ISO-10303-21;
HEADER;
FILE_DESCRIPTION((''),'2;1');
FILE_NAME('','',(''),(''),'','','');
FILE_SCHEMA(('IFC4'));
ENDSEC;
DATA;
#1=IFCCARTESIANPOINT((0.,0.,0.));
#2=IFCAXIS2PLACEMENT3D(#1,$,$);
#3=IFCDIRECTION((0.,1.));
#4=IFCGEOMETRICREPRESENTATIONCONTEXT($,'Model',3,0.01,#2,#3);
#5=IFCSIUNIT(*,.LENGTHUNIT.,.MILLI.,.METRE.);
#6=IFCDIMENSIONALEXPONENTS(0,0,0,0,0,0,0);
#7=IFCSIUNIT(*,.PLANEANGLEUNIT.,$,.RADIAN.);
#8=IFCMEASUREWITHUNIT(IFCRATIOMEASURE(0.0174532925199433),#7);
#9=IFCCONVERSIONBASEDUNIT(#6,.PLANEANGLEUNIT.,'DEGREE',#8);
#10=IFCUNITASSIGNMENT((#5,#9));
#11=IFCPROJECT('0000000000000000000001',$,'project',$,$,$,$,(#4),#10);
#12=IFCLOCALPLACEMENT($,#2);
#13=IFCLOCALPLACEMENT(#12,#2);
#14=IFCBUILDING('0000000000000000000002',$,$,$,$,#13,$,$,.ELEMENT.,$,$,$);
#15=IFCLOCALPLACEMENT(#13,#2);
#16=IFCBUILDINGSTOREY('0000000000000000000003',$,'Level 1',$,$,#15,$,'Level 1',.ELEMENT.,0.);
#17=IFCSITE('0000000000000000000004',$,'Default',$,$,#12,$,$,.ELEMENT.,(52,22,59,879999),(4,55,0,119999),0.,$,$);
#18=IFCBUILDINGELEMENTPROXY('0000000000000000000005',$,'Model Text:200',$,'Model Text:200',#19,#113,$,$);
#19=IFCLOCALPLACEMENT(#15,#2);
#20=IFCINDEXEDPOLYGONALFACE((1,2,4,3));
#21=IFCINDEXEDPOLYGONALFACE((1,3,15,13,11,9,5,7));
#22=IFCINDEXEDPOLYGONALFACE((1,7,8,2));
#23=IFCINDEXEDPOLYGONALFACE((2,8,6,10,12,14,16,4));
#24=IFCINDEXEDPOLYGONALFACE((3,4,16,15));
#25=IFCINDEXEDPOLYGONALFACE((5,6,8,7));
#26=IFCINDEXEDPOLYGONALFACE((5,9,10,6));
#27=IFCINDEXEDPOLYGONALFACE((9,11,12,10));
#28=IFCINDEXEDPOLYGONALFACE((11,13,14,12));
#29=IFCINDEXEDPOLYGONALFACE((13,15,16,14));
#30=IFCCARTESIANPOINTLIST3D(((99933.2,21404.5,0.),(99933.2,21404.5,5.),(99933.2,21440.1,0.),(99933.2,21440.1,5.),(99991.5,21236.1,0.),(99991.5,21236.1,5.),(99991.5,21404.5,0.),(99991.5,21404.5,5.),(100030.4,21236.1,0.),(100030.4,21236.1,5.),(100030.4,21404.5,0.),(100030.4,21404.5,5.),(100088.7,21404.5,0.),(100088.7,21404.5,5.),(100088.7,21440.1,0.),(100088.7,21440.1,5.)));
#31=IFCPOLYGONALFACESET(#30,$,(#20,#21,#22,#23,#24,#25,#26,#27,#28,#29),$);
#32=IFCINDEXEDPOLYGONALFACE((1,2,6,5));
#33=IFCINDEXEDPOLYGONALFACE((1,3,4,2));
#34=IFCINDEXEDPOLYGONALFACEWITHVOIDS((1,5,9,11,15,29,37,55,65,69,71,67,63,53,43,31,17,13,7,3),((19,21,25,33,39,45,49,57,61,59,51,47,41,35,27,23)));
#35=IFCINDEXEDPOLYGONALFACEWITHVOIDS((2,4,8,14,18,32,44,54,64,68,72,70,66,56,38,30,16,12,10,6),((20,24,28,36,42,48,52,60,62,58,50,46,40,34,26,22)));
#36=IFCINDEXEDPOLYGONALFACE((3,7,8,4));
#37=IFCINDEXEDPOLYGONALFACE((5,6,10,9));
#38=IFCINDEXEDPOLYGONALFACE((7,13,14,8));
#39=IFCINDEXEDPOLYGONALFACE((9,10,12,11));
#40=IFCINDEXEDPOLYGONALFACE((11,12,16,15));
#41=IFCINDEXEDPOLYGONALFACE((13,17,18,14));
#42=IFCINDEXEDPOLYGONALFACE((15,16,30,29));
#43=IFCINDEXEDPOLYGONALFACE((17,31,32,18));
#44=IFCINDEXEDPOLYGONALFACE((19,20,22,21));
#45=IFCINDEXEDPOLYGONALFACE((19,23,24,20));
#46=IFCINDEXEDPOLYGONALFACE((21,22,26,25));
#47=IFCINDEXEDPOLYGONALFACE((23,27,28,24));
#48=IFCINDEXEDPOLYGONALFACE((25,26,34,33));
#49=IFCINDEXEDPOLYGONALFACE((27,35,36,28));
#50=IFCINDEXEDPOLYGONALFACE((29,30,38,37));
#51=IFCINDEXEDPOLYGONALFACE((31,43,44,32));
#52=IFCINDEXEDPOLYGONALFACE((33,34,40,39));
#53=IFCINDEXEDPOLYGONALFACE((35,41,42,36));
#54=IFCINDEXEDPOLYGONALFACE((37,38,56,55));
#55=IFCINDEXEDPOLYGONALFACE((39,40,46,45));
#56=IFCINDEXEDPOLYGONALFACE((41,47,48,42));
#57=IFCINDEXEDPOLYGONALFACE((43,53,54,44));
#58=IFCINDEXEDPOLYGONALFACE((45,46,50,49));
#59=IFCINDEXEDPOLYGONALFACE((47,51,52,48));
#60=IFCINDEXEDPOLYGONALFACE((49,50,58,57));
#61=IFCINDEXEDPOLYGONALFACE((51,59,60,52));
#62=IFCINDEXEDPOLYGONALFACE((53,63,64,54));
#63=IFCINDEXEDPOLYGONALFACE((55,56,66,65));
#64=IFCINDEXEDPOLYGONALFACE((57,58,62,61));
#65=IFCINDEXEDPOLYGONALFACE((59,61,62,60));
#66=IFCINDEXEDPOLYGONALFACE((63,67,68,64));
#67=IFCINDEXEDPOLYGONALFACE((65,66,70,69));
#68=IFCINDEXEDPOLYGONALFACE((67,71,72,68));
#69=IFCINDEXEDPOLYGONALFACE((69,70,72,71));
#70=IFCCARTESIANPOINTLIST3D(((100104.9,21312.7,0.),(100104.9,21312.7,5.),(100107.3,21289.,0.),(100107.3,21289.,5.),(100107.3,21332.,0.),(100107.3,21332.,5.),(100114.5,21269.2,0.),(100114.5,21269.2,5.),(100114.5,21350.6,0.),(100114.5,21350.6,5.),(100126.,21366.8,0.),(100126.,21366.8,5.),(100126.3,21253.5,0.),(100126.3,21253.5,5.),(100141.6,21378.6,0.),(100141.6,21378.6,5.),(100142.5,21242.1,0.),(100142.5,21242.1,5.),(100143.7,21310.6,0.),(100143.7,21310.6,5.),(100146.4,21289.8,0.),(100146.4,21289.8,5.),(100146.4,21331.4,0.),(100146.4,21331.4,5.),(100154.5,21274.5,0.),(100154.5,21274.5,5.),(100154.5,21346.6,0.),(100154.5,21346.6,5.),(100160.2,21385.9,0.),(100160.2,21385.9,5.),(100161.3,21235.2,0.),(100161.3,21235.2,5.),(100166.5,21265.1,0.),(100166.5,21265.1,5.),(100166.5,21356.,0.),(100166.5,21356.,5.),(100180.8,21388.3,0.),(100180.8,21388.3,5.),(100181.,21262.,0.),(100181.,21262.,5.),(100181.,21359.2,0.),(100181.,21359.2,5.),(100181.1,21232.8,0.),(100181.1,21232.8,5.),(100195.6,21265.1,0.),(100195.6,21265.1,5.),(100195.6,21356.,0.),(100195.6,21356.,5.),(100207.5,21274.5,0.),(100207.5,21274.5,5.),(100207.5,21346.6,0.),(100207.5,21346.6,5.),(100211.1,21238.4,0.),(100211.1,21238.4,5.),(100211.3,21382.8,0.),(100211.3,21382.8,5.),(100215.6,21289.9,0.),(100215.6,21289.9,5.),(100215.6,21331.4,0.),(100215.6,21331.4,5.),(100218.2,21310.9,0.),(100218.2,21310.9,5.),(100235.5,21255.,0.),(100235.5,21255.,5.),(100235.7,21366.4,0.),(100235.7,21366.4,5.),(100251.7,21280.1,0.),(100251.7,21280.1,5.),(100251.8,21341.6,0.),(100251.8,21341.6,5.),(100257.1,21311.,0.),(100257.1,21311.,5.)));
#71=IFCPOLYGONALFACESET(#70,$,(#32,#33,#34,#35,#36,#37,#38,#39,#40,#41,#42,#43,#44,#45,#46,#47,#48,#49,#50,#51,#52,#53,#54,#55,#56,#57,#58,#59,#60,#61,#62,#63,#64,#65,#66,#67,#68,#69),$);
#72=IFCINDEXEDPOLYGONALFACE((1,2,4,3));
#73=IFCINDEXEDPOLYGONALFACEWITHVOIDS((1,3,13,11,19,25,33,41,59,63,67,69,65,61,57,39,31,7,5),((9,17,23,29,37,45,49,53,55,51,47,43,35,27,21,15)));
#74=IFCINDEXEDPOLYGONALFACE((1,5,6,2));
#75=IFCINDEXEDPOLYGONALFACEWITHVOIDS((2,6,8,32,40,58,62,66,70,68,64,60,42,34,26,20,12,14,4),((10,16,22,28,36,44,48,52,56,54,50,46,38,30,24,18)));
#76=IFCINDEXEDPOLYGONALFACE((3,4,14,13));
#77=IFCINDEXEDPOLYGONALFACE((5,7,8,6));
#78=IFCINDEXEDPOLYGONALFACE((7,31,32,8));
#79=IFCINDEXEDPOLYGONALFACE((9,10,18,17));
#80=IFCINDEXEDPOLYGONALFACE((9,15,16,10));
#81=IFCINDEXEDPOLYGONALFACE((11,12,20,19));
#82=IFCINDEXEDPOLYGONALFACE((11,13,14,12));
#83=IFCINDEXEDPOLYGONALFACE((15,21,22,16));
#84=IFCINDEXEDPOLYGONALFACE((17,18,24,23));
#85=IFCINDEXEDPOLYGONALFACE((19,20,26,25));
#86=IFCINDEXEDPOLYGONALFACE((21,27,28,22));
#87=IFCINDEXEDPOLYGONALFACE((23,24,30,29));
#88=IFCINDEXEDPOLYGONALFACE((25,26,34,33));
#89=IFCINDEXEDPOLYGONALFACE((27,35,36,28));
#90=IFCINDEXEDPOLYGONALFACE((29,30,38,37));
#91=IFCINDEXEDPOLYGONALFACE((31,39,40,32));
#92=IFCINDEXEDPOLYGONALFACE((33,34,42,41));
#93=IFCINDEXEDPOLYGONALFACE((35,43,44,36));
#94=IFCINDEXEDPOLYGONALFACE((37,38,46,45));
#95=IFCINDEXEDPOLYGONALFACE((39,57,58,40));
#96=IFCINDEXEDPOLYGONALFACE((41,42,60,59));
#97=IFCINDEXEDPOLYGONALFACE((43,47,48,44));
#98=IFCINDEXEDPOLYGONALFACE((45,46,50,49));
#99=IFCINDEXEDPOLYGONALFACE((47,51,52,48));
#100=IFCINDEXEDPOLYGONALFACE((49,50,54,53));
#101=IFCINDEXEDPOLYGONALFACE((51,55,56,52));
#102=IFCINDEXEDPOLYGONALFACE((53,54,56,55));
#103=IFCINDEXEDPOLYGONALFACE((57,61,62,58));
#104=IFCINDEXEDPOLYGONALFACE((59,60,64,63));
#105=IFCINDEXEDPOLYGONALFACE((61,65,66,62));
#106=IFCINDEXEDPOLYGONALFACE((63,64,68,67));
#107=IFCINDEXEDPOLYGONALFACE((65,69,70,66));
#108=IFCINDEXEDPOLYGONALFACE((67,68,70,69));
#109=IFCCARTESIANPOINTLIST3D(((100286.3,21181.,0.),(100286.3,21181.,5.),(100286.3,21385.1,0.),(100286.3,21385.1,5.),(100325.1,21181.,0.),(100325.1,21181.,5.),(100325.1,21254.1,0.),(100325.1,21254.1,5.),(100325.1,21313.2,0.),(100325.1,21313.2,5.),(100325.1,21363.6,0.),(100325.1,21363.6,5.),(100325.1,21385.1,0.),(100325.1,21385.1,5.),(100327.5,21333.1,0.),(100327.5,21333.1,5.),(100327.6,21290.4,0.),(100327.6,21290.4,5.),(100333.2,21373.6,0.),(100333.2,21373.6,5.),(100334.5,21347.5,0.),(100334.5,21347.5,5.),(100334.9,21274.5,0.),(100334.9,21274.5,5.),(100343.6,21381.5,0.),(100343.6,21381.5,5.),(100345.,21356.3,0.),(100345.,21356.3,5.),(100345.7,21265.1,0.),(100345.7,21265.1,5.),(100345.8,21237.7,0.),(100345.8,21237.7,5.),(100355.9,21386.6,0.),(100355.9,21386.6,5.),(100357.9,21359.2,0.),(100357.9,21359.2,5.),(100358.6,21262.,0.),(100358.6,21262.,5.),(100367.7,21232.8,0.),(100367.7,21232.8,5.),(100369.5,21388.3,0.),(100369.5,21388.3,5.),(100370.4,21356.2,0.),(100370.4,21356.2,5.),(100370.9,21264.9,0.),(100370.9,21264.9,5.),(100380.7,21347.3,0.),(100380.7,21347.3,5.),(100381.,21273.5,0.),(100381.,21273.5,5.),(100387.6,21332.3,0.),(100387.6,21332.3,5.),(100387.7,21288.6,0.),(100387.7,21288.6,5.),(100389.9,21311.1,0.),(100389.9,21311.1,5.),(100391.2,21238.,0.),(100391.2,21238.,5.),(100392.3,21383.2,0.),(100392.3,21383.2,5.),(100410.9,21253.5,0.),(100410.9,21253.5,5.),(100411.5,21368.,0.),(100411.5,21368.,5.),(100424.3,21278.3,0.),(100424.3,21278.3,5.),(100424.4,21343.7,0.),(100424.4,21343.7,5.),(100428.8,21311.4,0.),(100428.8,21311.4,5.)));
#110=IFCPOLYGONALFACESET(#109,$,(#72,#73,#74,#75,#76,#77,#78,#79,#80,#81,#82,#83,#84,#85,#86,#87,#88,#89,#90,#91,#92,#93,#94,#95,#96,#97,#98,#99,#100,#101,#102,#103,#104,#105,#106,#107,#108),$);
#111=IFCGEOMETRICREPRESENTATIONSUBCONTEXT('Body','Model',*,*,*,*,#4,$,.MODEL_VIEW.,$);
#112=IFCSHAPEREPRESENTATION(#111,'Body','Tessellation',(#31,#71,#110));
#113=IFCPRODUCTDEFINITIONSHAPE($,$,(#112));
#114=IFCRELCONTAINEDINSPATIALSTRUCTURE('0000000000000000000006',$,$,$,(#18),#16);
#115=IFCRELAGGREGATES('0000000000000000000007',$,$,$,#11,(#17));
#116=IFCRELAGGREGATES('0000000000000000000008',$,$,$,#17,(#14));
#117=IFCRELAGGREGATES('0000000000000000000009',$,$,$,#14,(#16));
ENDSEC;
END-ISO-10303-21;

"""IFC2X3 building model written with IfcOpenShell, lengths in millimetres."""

from ifc_helpers import new_model, entity, si_unit, converted_unit, direction, frame, origin, place, context, subcontext, project, spatial, polyline, outline, extrude, element, save


model = new_model("IFC2X3")

# Units and contexts
model_context = context("Model", 3, precision=0.01, world=origin(), true_north=direction((0.0, 1.0)))
body_context = subcontext(model_context, "Body", "Model", "MODEL_VIEW")
ifc_project = project(units=[si_unit("LENGTHUNIT", "METRE", prefix="MILLI"), converted_unit("PLANEANGLEUNIT", "DEGREE", entity("IfcRatioMeasure", 0.0174532925199433), si_unit("PLANEANGLEUNIT", "RADIAN"), dimensions=[0, 0, 0, 0, 0, 0, 0])], contexts=[model_context])

# Site, building, storey
site_placement = place(None, origin())
site = spatial("IfcSite", under=ifc_project, at=site_placement, Name="Default", CompositionType="ELEMENT", RefLatitude=(52, 22, 59, 879999), RefLongitude=(4, 55, 0, 119999), RefElevation=0.0)
building_placement = place(site_placement, origin())
building = spatial("IfcBuilding", under=site, at=building_placement, CompositionType="ELEMENT")
storey_placement = place(building_placement, origin())
storey = spatial("IfcBuildingStorey", under=building, at=storey_placement, Name="Level 1", LongName="Level 1", CompositionType="ELEMENT", Elevation=0.0)

# Building element proxy
proxy_1_placement = place(building_placement, origin())
element("IfcBuildingElementProxy", 1, at=proxy_1_placement, inside=storey, Name="Model Text:200", ObjectType="Model Text:200", context=body_context, shape_type="SweptSolid", body=[
    extrude(outline(polyline([(-19.4, -135.2), (19.4, -135.2), (19.4, 33.2), (77.7, 33.2), (77.7, 68.8), (-77.7, 68.8), (-77.7, 33.2), (-19.4, 33.2), (-19.4, -135.2)])), frame((100010.9, 21371.3, 0.0)), (0.0, 0.0, 1.0), 5.0),
    extrude(outline(polyline([(-8.8, -65.7), (15.1, -65.7), (35.5, -60.5), (52.3, -50.4), (65.3, -35.4), (74.1, -17.3), (78.4, 2.1), (75.9, 32.5), (61.8, 58.5), (38.4, 77.1), (8.3, 85.6), (-22.7, 83.3), (-49.0, 69.9), (-67.8, 47.3), (-76.3, 17.5), (-76.0, -3.3), (-70.7, -22.5), (-60.5, -39.2), (-45.5, -52.3), (-27.7, -61.4), (-8.8, -65.7)]), holes=[polyline([(-2.7, -27.2), (-23.1, -22.5), (-37.5, -12.9), (-45.7, 0.0), (-47.3, 14.8), (-42.7, 28.9), (-32.2, 39.9), (-16.3, 46.3), (4.5, 46.9), (25.1, 42.1), (39.6, 32.6), (47.7, 19.7), (49.4, 5.0), (44.8, -9.2), (34.2, -20.2), (18.2, -26.7), (-2.7, -27.2)])]), frame((100171.1, 21310.6, 0.0), z_axis=(0.0, 0.0, 1.0), x_axis=(0.100608, -0.994926, 0.0)), (0.0, 0.0, 1.0), 5.0),
    extrude(outline(polyline([(-73.1, -75.4), (130.9, -75.4), (130.9, -36.6), (57.8, -36.6), (74.3, -15.9), (79.1, 6.0), (73.9, 29.5), (58.4, 49.2), (33.6, 62.6), (0.5, 67.1), (-31.8, 62.8), (-56.1, 49.8), (-71.3, 30.7), (-76.4, 7.8), (-74.7, -5.8), (-69.6, -18.1), (-61.7, -28.5), (-51.7, -36.6), (-73.1, -36.6), (-73.1, -75.4)]), holes=[polyline([(-1.2, -36.6), (-21.2, -34.2), (-35.6, -27.2), (-44.3, -16.7), (-47.2, -3.8), (-44.3, 8.7), (-35.4, 19.0), (-20.4, 25.9), (0.8, 28.2), (23.3, 26.0), (38.5, 19.3), (47.1, 9.2), (49.9, -3.1), (46.8, -16.0), (37.4, -26.8), (21.5, -34.1), (-1.2, -36.6)])]), frame((100361.7, 21311.9, 0.0), z_axis=(0.0, 0.0, 1.0), x_axis=(0.0, -1.0, 0.0)), (0.0, 0.0, 1.0), 5.0),
])

save(model, "model.ifc")
